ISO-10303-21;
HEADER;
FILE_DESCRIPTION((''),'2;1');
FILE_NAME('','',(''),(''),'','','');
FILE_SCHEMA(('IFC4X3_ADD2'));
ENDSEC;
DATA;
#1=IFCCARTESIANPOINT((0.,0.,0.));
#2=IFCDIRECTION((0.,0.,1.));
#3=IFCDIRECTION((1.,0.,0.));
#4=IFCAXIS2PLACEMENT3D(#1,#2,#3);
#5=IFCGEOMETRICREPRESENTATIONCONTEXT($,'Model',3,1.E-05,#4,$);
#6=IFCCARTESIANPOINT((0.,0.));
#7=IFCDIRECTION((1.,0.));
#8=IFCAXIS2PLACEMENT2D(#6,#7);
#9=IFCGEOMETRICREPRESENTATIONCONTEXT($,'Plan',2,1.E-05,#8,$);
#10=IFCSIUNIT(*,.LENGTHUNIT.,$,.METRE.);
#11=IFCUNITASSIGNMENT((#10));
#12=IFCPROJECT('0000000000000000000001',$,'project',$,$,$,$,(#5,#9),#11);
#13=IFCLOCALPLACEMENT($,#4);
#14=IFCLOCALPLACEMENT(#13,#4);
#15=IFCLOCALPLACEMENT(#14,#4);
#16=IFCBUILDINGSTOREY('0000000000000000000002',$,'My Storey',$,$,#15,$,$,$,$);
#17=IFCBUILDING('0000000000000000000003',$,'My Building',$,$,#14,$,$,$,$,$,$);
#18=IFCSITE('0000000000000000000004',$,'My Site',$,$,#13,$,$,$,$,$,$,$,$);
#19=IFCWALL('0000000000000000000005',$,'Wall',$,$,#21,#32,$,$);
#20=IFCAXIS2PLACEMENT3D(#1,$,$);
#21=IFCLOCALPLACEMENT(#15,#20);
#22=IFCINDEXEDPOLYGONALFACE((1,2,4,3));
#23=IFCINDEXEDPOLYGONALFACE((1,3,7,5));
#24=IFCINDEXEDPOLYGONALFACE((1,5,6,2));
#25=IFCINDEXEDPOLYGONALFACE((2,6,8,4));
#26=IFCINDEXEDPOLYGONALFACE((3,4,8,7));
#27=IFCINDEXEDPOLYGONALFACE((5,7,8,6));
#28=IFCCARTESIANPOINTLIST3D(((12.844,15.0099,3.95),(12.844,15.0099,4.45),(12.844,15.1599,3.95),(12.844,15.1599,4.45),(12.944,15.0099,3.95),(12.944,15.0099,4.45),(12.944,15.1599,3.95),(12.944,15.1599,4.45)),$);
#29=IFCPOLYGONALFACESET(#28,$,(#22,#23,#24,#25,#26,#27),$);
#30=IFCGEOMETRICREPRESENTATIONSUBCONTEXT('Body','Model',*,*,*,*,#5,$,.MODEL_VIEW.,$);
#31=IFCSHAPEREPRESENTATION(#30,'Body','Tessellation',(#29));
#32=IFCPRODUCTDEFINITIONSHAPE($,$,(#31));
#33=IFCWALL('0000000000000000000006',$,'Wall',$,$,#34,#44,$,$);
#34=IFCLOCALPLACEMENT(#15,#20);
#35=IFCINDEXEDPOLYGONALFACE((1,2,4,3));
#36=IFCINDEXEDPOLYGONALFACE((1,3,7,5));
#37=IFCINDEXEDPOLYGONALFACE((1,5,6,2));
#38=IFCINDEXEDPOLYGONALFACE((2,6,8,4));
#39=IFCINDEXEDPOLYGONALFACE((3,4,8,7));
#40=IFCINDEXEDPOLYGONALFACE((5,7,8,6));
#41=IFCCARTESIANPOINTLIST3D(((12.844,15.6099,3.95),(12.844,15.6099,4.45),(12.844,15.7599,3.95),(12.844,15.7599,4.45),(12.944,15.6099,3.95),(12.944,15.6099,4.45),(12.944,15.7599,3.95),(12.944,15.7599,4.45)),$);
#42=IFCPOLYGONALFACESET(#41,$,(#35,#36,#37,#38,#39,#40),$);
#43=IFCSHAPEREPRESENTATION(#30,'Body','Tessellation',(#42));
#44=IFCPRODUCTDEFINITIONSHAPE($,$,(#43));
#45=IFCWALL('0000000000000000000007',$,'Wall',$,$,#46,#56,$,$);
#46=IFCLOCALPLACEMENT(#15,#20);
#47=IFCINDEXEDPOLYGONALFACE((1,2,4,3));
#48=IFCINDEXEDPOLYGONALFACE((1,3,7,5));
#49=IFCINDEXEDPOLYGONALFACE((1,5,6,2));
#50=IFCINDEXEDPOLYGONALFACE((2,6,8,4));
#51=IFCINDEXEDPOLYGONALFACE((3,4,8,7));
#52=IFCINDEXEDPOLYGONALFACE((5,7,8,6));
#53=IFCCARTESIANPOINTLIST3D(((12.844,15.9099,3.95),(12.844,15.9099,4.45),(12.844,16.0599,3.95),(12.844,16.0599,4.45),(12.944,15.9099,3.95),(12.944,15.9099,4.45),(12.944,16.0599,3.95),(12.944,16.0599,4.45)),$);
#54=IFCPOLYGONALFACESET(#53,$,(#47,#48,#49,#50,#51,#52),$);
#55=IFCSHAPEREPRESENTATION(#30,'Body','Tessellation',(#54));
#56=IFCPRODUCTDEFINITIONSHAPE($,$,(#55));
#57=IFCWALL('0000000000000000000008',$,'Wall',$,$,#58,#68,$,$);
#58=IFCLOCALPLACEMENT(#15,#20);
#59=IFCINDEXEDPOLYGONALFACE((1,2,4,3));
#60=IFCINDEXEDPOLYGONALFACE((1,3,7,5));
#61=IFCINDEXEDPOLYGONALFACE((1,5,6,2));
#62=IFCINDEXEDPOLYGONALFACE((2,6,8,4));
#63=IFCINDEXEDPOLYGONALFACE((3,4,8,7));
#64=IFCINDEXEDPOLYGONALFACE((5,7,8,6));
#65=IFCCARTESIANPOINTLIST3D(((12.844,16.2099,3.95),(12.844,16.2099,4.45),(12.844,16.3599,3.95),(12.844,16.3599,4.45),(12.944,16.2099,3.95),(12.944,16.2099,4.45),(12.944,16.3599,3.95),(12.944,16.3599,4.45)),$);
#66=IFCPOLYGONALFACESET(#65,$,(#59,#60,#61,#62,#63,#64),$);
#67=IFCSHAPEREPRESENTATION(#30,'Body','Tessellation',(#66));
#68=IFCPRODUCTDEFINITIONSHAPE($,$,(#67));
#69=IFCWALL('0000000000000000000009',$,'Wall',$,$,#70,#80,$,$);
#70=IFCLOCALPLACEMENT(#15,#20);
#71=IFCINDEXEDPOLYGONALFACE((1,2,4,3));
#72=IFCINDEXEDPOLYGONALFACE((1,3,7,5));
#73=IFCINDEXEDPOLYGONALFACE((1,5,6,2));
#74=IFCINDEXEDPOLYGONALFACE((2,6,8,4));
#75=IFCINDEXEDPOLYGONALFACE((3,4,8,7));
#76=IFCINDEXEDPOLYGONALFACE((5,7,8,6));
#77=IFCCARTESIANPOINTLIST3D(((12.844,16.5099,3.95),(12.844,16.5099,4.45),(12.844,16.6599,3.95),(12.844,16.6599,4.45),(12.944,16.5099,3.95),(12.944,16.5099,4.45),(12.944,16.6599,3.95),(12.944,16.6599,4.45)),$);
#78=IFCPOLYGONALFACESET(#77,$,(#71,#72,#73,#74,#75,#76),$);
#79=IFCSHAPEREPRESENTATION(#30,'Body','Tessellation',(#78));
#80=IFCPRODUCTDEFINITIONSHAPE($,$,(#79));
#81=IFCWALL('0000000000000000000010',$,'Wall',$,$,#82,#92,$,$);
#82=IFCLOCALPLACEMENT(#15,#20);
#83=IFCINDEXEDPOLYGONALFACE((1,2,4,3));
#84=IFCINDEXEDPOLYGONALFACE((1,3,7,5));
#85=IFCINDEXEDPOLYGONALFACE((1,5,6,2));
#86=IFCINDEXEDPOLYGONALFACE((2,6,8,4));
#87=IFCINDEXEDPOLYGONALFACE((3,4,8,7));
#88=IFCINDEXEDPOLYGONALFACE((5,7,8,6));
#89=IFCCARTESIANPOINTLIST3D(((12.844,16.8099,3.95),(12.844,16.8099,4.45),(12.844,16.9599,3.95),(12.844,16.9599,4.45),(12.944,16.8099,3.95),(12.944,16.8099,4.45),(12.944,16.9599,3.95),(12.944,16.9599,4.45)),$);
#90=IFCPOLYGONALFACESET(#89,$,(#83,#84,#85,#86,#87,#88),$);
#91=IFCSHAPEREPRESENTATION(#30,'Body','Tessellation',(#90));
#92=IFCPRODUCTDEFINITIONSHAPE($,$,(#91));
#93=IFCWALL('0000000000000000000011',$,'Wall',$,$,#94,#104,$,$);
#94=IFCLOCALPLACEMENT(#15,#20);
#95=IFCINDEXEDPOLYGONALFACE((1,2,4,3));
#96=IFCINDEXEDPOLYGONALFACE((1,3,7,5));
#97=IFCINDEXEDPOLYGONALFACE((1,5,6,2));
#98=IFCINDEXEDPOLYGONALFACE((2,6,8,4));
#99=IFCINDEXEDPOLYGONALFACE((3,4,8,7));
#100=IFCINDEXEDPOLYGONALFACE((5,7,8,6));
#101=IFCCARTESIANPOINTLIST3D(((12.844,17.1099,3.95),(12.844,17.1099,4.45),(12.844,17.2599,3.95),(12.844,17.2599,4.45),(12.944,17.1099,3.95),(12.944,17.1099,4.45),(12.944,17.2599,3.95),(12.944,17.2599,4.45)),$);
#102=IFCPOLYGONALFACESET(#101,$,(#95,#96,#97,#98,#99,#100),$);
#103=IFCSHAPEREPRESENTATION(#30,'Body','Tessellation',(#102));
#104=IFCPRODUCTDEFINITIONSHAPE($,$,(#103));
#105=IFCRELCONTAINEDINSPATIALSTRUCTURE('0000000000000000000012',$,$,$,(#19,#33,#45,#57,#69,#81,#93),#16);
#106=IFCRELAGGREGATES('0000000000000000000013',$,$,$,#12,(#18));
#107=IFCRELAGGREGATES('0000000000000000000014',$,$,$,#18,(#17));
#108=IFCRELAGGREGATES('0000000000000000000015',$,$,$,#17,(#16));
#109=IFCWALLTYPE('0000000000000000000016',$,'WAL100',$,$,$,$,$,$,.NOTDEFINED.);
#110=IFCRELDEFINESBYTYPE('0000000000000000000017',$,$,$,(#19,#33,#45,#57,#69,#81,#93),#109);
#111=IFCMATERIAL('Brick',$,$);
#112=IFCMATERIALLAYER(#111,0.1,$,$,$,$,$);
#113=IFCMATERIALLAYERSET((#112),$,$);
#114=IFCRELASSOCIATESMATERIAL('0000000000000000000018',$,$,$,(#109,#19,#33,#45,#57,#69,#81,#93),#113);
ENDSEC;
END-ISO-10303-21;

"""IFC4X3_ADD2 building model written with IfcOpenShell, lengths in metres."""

from ifc_helpers import new_model, si_unit, frame, origin_with_axes, origin_2d_with_axis, place, context, subcontext, project, spatial, line, indexed_curve, outline, extrude, material, layer, layer_set, layer_usage, type_object, element, save


model = new_model("IFC4X3_ADD2")

# Units and contexts
model_context = context("Model", 3, precision=1e-05, world=origin_with_axes())
plan_context = context("Plan", 2, precision=1e-05, world=origin_2d_with_axis())
body_context = subcontext(model_context, "Body", "Model", "MODEL_VIEW")
ifc_project = project(units=[si_unit("LENGTHUNIT", "METRE")], contexts=[model_context, plan_context])

# Site, building, storey
site_placement = place(None, origin_with_axes())
site = spatial("IfcSite", under=ifc_project, at=site_placement, Name="My Site")
building_placement = place(site_placement, origin_with_axes())
building = spatial("IfcBuilding", under=site, at=building_placement, Name="My Building")
storey_placement = place(building_placement, origin_with_axes())
storey = spatial("IfcBuildingStorey", under=building, at=storey_placement, Name="My Storey")

# Walls
ifc_material_1 = material(Name="Brick")
ifc_layer = layer(ifc_material_1, 0.1)
ifc_layer_set = layer_set([ifc_layer])
wall_type = type_object("IfcWallType", Name="WAL100", PredefinedType="NOTDEFINED", material=ifc_layer_set)
ifc_layer_usage_1 = layer_usage(ifc_layer_set, "AXIS2", "POSITIVE", 0.0)
wall_1_placement = place(storey_placement, frame((12.944, 15.0099, 3.95), z_axis=(0.0, 0.0, 1.0), x_axis=(-0.000005, 1.0, 0.0)))
element("IfcWall", 1, at=wall_1_placement, inside=storey, type_object=wall_type, material=ifc_layer_usage_1, Name="Wall", context=body_context, shape_type="SweptSolid", body=[
    extrude(outline(indexed_curve([(0.0, 0.0), (0.0, 0.1), (0.15, 0.1), (0.15, 0.0)], segments=[line(1, 2, 3, 4, 1)])), origin_with_axes(), (0.0, 0.0, 1.0), 0.5),
])
ifc_layer_usage_2 = layer_usage(ifc_layer_set, "AXIS2", "POSITIVE", 0.0)
wall_2_placement = place(storey_placement, frame((12.944, 15.6099, 3.95), z_axis=(0.0, 0.0, 1.0), x_axis=(-0.000005, 1.0, 0.0)))
element("IfcWall", 2, at=wall_2_placement, inside=storey, type_object=wall_type, material=ifc_layer_usage_2, Name="Wall", context=body_context, shape_type="SweptSolid", body=[
    extrude(outline(indexed_curve([(0.0, 0.0), (0.0, 0.1), (0.15, 0.1), (0.15, 0.0)], segments=[line(1, 2, 3, 4, 1)])), origin_with_axes(), (0.0, 0.0, 1.0), 0.5),
])
ifc_layer_usage_3 = layer_usage(ifc_layer_set, "AXIS2", "POSITIVE", 0.0)
wall_3_placement = place(storey_placement, frame((12.944, 15.9099, 3.95), z_axis=(0.0, 0.0, 1.0), x_axis=(-0.000005, 1.0, 0.0)))
element("IfcWall", 3, at=wall_3_placement, inside=storey, type_object=wall_type, material=ifc_layer_usage_3, Name="Wall", context=body_context, shape_type="SweptSolid", body=[
    extrude(outline(indexed_curve([(0.0, 0.0), (0.0, 0.1), (0.15, 0.1), (0.15, 0.0)], segments=[line(1, 2, 3, 4, 1)])), origin_with_axes(), (0.0, 0.0, 1.0), 0.5),
])
ifc_layer_usage_4 = layer_usage(ifc_layer_set, "AXIS2", "POSITIVE", 0.0)
wall_4_placement = place(storey_placement, frame((12.944, 16.2099, 3.95), z_axis=(0.0, 0.0, 1.0), x_axis=(-0.000005, 1.0, 0.0)))
element("IfcWall", 4, at=wall_4_placement, inside=storey, type_object=wall_type, material=ifc_layer_usage_4, Name="Wall", context=body_context, shape_type="SweptSolid", body=[
    extrude(outline(indexed_curve([(0.0, 0.0), (0.0, 0.1), (0.15, 0.1), (0.15, 0.0)], segments=[line(1, 2, 3, 4, 1)])), origin_with_axes(), (0.0, 0.0, 1.0), 0.5),
])
ifc_layer_usage_5 = layer_usage(ifc_layer_set, "AXIS2", "POSITIVE", 0.0)
wall_5_placement = place(storey_placement, frame((12.944, 16.5099, 3.95), z_axis=(0.0, 0.0, 1.0), x_axis=(-0.000005, 1.0, 0.0)))
element("IfcWall", 5, at=wall_5_placement, inside=storey, type_object=wall_type, material=ifc_layer_usage_5, Name="Wall", context=body_context, shape_type="SweptSolid", body=[
    extrude(outline(indexed_curve([(0.0, 0.0), (0.0, 0.1), (0.15, 0.1), (0.15, 0.0)], segments=[line(1, 2, 3, 4, 1)])), origin_with_axes(), (0.0, 0.0, 1.0), 0.5),
])
ifc_layer_usage_6 = layer_usage(ifc_layer_set, "AXIS2", "POSITIVE", 0.0)
wall_6_placement = place(storey_placement, frame((12.944, 16.8099, 3.95), z_axis=(0.0, 0.0, 1.0), x_axis=(-0.000005, 1.0, 0.0)))
element("IfcWall", 6, at=wall_6_placement, inside=storey, type_object=wall_type, material=ifc_layer_usage_6, Name="Wall", context=body_context, shape_type="SweptSolid", body=[
    extrude(outline(indexed_curve([(0.0, 0.0), (0.0, 0.1), (0.15, 0.1), (0.15, 0.0)], segments=[line(1, 2, 3, 4, 1)])), origin_with_axes(), (0.0, 0.0, 1.0), 0.5),
])
ifc_layer_usage_7 = layer_usage(ifc_layer_set, "AXIS2", "POSITIVE", 0.0)
wall_7_placement = place(storey_placement, frame((12.944, 17.1099, 3.95), z_axis=(0.0, 0.0, 1.0), x_axis=(-0.000005, 1.0, 0.0)))
element("IfcWall", 7, at=wall_7_placement, inside=storey, type_object=wall_type, material=ifc_layer_usage_7, Name="Wall", context=body_context, shape_type="SweptSolid", body=[
    extrude(outline(indexed_curve([(0.0, 0.0), (0.0, 0.1), (0.15, 0.1), (0.15, 0.0)], segments=[line(1, 2, 3, 4, 1)])), origin_with_axes(), (0.0, 0.0, 1.0), 0.5),
])

save(model, "model.ifc")
